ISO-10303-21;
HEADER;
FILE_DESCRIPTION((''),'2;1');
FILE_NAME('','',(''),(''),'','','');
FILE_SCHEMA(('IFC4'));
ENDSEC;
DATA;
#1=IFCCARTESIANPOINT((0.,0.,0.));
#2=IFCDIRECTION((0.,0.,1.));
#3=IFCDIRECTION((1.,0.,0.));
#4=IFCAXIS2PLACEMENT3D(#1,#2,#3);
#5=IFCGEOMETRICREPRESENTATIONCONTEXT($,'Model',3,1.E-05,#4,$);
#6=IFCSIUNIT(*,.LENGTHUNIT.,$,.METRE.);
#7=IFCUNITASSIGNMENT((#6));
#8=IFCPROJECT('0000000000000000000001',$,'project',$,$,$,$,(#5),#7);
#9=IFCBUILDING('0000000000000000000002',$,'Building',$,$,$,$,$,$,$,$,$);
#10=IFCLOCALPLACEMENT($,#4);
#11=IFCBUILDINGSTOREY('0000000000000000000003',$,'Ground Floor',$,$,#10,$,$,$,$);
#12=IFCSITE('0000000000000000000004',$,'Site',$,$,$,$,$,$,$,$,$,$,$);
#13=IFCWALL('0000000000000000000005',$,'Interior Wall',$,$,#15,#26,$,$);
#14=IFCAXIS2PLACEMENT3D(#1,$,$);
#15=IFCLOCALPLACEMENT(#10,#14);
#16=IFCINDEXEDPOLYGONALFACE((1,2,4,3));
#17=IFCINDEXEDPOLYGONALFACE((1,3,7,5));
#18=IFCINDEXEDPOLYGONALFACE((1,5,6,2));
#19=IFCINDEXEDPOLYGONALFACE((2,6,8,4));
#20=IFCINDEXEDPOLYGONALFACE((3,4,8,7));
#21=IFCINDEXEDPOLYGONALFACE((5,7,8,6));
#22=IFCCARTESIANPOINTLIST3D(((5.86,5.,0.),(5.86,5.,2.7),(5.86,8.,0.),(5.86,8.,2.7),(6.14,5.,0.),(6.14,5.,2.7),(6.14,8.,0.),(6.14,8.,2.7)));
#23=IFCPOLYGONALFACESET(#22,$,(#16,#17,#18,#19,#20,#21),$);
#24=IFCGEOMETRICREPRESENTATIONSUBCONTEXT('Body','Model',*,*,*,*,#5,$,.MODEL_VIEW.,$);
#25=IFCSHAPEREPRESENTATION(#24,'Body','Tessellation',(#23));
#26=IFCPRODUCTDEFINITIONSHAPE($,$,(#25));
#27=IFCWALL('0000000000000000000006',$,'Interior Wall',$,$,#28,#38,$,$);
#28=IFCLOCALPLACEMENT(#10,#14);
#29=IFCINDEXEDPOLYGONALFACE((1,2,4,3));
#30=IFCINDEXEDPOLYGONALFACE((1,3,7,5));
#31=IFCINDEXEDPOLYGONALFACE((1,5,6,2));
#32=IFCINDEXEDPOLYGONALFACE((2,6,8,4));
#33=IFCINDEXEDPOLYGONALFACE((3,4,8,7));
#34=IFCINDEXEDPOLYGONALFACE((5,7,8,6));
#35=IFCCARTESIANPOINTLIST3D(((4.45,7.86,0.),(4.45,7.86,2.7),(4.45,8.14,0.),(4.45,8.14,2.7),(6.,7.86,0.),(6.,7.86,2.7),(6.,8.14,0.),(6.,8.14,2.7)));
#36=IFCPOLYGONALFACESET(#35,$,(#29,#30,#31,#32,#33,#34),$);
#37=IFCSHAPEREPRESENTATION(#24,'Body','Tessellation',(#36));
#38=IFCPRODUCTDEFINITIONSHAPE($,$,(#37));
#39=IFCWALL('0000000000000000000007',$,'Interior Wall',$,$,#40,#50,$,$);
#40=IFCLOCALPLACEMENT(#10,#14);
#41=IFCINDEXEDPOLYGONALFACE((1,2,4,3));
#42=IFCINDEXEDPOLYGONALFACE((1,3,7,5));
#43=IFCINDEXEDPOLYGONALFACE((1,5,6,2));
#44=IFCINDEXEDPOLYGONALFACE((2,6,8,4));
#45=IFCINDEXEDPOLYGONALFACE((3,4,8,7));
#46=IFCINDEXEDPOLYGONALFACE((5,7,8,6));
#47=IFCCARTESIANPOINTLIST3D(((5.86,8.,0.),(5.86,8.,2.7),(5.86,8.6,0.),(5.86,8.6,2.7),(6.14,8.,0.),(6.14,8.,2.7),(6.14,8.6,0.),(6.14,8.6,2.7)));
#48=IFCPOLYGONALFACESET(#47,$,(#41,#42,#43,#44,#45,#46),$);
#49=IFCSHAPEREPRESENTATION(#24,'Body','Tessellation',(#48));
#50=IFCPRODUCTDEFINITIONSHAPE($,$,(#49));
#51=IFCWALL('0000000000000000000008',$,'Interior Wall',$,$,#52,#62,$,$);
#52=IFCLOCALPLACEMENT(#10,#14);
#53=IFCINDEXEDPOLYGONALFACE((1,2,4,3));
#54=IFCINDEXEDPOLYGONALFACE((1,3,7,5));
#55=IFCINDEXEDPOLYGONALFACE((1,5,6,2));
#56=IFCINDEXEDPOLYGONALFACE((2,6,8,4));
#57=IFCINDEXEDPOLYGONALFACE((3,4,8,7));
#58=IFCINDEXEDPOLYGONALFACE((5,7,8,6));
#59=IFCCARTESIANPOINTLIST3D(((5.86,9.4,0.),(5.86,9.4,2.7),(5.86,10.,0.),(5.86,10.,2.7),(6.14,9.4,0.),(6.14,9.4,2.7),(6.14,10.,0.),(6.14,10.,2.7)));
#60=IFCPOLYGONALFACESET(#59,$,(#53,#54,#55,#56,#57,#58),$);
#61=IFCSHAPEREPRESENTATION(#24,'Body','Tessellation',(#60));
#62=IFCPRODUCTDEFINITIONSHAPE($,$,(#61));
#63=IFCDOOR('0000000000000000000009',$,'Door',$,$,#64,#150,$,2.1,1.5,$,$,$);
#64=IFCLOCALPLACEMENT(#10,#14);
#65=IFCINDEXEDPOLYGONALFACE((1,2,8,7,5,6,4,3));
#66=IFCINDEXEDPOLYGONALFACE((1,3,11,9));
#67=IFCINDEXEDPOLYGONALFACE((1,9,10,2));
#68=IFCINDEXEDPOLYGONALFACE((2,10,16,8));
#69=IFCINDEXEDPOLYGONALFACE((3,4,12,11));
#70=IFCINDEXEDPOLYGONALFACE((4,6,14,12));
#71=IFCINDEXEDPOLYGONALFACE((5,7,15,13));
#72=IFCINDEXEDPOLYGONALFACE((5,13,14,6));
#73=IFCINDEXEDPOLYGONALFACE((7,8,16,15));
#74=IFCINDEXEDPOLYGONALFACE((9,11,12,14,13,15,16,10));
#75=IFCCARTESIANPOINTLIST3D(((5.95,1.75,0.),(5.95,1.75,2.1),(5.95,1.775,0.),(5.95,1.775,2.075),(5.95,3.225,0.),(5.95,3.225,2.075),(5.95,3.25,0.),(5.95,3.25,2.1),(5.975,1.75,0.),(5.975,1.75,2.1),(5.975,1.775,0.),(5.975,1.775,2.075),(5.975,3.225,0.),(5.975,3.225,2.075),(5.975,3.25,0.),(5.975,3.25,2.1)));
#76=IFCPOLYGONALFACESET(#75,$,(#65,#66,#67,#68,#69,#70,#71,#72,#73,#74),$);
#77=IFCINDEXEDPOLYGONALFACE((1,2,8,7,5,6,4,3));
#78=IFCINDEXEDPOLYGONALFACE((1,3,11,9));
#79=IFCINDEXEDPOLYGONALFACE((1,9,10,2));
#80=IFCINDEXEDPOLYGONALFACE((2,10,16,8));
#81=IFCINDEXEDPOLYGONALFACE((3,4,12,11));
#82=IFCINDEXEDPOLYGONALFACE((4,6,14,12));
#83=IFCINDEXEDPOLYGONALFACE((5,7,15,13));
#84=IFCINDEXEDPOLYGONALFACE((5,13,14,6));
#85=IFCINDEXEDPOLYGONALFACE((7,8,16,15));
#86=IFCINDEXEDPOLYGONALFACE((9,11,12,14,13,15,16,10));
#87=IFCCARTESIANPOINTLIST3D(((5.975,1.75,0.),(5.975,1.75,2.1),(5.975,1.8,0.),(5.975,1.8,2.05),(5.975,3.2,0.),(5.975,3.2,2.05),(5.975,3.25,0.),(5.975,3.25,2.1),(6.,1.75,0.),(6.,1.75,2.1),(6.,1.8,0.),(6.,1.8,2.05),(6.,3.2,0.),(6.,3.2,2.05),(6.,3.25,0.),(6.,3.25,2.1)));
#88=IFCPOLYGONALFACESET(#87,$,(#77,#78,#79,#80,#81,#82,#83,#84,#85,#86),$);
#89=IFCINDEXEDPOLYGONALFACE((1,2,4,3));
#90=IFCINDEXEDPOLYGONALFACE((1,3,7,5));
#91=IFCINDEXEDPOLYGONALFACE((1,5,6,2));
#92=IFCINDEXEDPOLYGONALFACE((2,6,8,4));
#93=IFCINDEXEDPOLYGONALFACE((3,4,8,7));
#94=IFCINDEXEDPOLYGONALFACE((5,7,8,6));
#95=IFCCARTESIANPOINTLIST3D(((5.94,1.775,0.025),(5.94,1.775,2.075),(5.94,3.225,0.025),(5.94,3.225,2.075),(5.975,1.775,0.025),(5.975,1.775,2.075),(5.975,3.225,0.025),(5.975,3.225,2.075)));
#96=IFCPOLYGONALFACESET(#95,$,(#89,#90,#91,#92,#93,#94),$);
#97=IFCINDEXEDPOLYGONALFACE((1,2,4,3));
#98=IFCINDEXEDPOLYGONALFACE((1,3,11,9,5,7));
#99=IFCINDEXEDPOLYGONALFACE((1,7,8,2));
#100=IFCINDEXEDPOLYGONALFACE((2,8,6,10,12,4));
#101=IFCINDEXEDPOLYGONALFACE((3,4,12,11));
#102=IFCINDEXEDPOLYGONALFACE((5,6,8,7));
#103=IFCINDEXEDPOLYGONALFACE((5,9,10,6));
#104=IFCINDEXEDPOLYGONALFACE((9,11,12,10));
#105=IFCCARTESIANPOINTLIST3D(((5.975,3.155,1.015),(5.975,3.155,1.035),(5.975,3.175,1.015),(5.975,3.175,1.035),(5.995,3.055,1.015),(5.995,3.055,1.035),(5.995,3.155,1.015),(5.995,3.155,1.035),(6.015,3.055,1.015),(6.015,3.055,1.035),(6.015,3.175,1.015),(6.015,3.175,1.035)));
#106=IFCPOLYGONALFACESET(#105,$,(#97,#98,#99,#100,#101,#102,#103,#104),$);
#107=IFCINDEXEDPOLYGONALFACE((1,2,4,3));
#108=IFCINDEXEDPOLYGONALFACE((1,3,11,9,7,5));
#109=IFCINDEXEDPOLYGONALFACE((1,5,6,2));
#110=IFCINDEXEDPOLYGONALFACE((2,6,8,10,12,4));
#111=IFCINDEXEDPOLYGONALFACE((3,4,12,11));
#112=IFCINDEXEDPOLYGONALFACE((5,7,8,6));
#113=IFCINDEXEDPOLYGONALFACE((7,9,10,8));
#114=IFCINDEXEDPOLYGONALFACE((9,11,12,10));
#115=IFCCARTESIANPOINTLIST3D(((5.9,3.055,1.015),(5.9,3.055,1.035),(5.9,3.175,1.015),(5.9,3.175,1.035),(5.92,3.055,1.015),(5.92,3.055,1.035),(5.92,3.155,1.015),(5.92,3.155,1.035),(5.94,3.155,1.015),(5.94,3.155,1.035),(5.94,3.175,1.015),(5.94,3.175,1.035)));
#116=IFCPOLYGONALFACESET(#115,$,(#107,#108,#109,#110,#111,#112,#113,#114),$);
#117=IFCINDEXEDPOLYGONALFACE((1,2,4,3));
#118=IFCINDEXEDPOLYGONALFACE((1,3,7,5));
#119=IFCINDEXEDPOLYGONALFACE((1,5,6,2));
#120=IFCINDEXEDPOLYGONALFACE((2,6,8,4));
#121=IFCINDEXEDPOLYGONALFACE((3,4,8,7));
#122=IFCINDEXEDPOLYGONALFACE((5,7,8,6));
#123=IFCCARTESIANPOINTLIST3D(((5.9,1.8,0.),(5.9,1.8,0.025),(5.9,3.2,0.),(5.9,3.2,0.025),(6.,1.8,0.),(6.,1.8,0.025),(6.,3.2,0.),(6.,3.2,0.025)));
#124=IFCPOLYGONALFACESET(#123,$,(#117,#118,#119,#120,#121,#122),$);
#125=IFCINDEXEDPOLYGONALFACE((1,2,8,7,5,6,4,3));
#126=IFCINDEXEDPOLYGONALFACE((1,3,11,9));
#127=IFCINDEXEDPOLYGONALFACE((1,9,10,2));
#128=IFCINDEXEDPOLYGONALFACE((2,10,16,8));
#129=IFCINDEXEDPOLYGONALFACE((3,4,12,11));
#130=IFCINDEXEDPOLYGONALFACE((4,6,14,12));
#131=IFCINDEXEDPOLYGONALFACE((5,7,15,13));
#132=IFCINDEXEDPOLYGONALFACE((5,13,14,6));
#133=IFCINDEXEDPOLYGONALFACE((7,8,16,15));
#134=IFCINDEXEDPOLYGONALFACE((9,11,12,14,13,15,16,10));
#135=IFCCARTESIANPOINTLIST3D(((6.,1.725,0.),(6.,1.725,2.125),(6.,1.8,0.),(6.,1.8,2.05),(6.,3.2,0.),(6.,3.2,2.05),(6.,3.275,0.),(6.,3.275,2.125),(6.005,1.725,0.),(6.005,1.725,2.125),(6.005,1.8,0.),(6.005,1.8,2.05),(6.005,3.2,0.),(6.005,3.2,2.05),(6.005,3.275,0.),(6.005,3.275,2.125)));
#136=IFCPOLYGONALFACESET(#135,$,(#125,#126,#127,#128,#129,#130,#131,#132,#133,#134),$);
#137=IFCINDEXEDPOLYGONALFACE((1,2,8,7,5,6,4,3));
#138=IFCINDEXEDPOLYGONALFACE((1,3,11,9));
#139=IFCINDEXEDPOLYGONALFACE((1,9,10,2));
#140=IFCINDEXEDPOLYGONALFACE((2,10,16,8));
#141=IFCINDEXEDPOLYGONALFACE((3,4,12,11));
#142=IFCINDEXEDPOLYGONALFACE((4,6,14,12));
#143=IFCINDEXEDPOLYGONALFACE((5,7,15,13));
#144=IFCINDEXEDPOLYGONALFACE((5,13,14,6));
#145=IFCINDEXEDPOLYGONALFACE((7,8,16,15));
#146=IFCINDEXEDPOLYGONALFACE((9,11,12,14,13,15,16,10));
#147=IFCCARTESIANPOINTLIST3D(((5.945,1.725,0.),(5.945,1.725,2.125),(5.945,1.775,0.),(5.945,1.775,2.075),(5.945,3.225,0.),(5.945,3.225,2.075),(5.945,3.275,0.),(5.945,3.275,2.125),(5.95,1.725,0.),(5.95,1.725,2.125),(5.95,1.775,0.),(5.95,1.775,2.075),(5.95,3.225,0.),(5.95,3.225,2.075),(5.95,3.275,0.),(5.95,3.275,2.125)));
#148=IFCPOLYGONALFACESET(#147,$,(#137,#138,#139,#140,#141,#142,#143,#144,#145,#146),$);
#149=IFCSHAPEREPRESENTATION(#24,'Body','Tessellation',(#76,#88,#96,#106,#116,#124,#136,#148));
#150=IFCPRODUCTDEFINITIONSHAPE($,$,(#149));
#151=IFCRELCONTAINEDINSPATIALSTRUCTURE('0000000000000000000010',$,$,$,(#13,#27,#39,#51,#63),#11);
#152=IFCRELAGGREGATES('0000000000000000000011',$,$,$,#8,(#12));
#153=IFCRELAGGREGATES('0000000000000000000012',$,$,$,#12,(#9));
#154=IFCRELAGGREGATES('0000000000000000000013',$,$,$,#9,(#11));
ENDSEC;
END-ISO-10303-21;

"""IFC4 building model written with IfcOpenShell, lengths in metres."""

from ifc_helpers import new_model, si_unit, frame, origin_with_axes, place, context, subcontext, project, spatial, line, indexed_curve, outline, extrude, element, save


model = new_model("IFC4")

# Units and contexts
model_context = context("Model", 3, precision=1e-05, world=origin_with_axes())
body_context = subcontext(model_context, "Body", "Model", "MODEL_VIEW")
ifc_project = project(units=[si_unit("LENGTHUNIT", "METRE")], contexts=[model_context])

# Site, building, storey
site = spatial("IfcSite", under=ifc_project, Name="Site")
building = spatial("IfcBuilding", under=site, Name="Building")
storey_placement = place(None, origin_with_axes())
storey = spatial("IfcBuildingStorey", under=building, at=storey_placement, Name="Ground Floor")

# Walls
wall_1_placement = place(storey_placement, frame((6.0, 8.0, 0.0), z_axis=(0.0, 0.0, 1.0), x_axis=(0.0, -1.0, 0.0)))
element("IfcWall", 1, at=wall_1_placement, inside=storey, Name="Interior Wall", context=body_context, shape_type="SweptSolid", body=[
    extrude(outline(indexed_curve([(0.0, 0.0), (0.0, 0.28), (3.0, 0.28), (3.0, 0.0), (0.0, 0.0)], self_intersect=False)), frame((0.0, -0.14, 0.0), z_axis=(0.0, 0.0, 1.0), x_axis=(1.0, 0.0, 0.0)), (0.0, 0.0, 1.0), 2.7),
])
wall_2_placement = place(storey_placement, frame((6.0, 8.0, 0.0), z_axis=(0.0, 0.0, 1.0), x_axis=(-1.0, 0.0, 0.0)))
element("IfcWall", 2, at=wall_2_placement, inside=storey, Name="Interior Wall", context=body_context, shape_type="SweptSolid", body=[
    extrude(outline(indexed_curve([(0.0, 0.0), (0.0, 0.28), (1.55, 0.28), (1.55, 0.0), (0.0, 0.0)], self_intersect=False)), frame((0.0, -0.14, 0.0), z_axis=(0.0, 0.0, 1.0), x_axis=(1.0, 0.0, 0.0)), (0.0, 0.0, 1.0), 2.7),
])
for number, where, z_axis, x_axis, name in (
    (3, (6.0, 8.0, 0.0), (0.0, 0.0, 1.0), (0.0, 1.0, 0.0), "Interior Wall"),
    (4, (6.0, 9.4, 0.0), (0.0, 0.0, 1.0), (0.0, 1.0, 0.0), "Interior Wall"),
):
    element("IfcWall", number, at=place(storey_placement, frame(where, z_axis=z_axis, x_axis=x_axis)), inside=storey, Name=name, context=body_context, shape_type="SweptSolid", body=[
        extrude(outline(indexed_curve([(0.0, 0.0), (0.0, 0.28), (0.6, 0.28), (0.6, 0.0), (0.0, 0.0)], self_intersect=False)), frame((0.0, -0.14, 0.0), z_axis=(0.0, 0.0, 1.0), x_axis=(1.0, 0.0, 0.0)), (0.0, 0.0, 1.0), 2.7),
    ])

# Door
door_1_placement = place(storey_placement, frame((6.0, 1.75, 0.0), z_axis=(0.0, 0.0, 1.0), x_axis=(0.0, 1.0, 0.0)))
element("IfcDoor", 5, at=door_1_placement, inside=storey, Name="Door", OverallHeight=2.1, OverallWidth=1.5, context=body_context, shape_type="SweptSolid", body=[
    extrude(outline(indexed_curve([(0.0, 0.0), (0.0, 2.1), (1.5, 2.1), (1.5, 0.0), (1.475, 0.0), (1.475, 2.075), (0.025, 2.075), (0.025, 0.0)], segments=[line(1, 2, 3, 4, 5, 6, 7, 8, 1)])), frame((0.0, 0.025, 0.0), z_axis=(0.0, -1.0, 0.0), x_axis=(1.0, 0.0, 0.0)), (0.0, 0.0, -1.0), 0.025),
    extrude(outline(indexed_curve([(0.0, 0.0), (0.0, 2.1), (1.5, 2.1), (1.5, 0.0), (1.45, 0.0), (1.45, 2.05), (0.05, 2.05), (0.05, 0.0)], segments=[line(1, 2, 3, 4, 5, 6, 7, 8, 1)])), frame((0.0, 0.0, 0.0), z_axis=(0.0, -1.0, 0.0), x_axis=(1.0, 0.0, 0.0)), (0.0, 0.0, -1.0), 0.025),
    extrude(outline(indexed_curve([(0.0, 0.0), (1.45, 0.0), (1.45, 0.035), (0.0, 0.035)], segments=[line(1, 2, 3, 4, 1)])), frame((0.025, 0.025, 0.025), z_axis=(0.0, 0.0, 1.0), x_axis=(1.0, 0.0, 0.0)), (0.0, 0.0, 1.0), 2.05),
    extrude(outline(indexed_curve([(0.0, 0.0), (0.0, -0.04), (-0.12, -0.04), (-0.12, -0.02), (-0.02, -0.02), (-0.02, 0.0)], segments=[line(1, 2, 3, 4, 5, 6, 1)])), frame((1.425, 0.025, 1.015), z_axis=(0.0, 0.0, 1.0), x_axis=(1.0, 0.0, 0.0)), (0.0, 0.0, 1.0), 0.02),
    extrude(outline(indexed_curve([(0.0, 0.0), (0.0, 0.04), (-0.12, 0.04), (-0.12, 0.02), (-0.02, 0.02), (-0.02, 0.0)], segments=[line(1, 2, 3, 4, 5, 6, 1)])), frame((1.425, 0.06, 1.015), z_axis=(0.0, 0.0, 1.0), x_axis=(1.0, 0.0, 0.0)), (0.0, 0.0, 1.0), 0.02),
    extrude(outline(indexed_curve([(0.0, 0.0), (1.4, 0.0), (1.4, 0.1), (0.0, 0.1)], segments=[line(1, 2, 3, 4, 1)])), frame((0.05, 0.0, 0.0), z_axis=(0.0, 0.0, 1.0), x_axis=(1.0, 0.0, 0.0)), (0.0, 0.0, 1.0), 0.025),
    extrude(outline(indexed_curve([(0.0, 0.0), (0.0, 2.125), (1.55, 2.125), (1.55, 0.0), (1.475, 0.0), (1.475, 2.05), (0.075, 2.05), (0.075, 0.0)], segments=[line(1, 2, 3, 4, 5, 6, 7, 8, 1)])), frame((-0.025, -0.005, 0.0), z_axis=(0.0, -1.0, 0.0), x_axis=(1.0, 0.0, 0.0)), (0.0, 0.0, -1.0), 0.005),
    extrude(outline(indexed_curve([(0.0, 0.0), (0.0, 2.125), (1.55, 2.125), (1.55, 0.0), (1.5, 0.0), (1.5, 2.075), (0.05, 2.075), (0.05, 0.0)], segments=[line(1, 2, 3, 4, 5, 6, 7, 8, 1)])), frame((-0.025, 0.05, 0.0), z_axis=(0.0, -1.0, 0.0), x_axis=(1.0, 0.0, 0.0)), (0.0, 0.0, -1.0), 0.005),
])

save(model, "model.ifc")
